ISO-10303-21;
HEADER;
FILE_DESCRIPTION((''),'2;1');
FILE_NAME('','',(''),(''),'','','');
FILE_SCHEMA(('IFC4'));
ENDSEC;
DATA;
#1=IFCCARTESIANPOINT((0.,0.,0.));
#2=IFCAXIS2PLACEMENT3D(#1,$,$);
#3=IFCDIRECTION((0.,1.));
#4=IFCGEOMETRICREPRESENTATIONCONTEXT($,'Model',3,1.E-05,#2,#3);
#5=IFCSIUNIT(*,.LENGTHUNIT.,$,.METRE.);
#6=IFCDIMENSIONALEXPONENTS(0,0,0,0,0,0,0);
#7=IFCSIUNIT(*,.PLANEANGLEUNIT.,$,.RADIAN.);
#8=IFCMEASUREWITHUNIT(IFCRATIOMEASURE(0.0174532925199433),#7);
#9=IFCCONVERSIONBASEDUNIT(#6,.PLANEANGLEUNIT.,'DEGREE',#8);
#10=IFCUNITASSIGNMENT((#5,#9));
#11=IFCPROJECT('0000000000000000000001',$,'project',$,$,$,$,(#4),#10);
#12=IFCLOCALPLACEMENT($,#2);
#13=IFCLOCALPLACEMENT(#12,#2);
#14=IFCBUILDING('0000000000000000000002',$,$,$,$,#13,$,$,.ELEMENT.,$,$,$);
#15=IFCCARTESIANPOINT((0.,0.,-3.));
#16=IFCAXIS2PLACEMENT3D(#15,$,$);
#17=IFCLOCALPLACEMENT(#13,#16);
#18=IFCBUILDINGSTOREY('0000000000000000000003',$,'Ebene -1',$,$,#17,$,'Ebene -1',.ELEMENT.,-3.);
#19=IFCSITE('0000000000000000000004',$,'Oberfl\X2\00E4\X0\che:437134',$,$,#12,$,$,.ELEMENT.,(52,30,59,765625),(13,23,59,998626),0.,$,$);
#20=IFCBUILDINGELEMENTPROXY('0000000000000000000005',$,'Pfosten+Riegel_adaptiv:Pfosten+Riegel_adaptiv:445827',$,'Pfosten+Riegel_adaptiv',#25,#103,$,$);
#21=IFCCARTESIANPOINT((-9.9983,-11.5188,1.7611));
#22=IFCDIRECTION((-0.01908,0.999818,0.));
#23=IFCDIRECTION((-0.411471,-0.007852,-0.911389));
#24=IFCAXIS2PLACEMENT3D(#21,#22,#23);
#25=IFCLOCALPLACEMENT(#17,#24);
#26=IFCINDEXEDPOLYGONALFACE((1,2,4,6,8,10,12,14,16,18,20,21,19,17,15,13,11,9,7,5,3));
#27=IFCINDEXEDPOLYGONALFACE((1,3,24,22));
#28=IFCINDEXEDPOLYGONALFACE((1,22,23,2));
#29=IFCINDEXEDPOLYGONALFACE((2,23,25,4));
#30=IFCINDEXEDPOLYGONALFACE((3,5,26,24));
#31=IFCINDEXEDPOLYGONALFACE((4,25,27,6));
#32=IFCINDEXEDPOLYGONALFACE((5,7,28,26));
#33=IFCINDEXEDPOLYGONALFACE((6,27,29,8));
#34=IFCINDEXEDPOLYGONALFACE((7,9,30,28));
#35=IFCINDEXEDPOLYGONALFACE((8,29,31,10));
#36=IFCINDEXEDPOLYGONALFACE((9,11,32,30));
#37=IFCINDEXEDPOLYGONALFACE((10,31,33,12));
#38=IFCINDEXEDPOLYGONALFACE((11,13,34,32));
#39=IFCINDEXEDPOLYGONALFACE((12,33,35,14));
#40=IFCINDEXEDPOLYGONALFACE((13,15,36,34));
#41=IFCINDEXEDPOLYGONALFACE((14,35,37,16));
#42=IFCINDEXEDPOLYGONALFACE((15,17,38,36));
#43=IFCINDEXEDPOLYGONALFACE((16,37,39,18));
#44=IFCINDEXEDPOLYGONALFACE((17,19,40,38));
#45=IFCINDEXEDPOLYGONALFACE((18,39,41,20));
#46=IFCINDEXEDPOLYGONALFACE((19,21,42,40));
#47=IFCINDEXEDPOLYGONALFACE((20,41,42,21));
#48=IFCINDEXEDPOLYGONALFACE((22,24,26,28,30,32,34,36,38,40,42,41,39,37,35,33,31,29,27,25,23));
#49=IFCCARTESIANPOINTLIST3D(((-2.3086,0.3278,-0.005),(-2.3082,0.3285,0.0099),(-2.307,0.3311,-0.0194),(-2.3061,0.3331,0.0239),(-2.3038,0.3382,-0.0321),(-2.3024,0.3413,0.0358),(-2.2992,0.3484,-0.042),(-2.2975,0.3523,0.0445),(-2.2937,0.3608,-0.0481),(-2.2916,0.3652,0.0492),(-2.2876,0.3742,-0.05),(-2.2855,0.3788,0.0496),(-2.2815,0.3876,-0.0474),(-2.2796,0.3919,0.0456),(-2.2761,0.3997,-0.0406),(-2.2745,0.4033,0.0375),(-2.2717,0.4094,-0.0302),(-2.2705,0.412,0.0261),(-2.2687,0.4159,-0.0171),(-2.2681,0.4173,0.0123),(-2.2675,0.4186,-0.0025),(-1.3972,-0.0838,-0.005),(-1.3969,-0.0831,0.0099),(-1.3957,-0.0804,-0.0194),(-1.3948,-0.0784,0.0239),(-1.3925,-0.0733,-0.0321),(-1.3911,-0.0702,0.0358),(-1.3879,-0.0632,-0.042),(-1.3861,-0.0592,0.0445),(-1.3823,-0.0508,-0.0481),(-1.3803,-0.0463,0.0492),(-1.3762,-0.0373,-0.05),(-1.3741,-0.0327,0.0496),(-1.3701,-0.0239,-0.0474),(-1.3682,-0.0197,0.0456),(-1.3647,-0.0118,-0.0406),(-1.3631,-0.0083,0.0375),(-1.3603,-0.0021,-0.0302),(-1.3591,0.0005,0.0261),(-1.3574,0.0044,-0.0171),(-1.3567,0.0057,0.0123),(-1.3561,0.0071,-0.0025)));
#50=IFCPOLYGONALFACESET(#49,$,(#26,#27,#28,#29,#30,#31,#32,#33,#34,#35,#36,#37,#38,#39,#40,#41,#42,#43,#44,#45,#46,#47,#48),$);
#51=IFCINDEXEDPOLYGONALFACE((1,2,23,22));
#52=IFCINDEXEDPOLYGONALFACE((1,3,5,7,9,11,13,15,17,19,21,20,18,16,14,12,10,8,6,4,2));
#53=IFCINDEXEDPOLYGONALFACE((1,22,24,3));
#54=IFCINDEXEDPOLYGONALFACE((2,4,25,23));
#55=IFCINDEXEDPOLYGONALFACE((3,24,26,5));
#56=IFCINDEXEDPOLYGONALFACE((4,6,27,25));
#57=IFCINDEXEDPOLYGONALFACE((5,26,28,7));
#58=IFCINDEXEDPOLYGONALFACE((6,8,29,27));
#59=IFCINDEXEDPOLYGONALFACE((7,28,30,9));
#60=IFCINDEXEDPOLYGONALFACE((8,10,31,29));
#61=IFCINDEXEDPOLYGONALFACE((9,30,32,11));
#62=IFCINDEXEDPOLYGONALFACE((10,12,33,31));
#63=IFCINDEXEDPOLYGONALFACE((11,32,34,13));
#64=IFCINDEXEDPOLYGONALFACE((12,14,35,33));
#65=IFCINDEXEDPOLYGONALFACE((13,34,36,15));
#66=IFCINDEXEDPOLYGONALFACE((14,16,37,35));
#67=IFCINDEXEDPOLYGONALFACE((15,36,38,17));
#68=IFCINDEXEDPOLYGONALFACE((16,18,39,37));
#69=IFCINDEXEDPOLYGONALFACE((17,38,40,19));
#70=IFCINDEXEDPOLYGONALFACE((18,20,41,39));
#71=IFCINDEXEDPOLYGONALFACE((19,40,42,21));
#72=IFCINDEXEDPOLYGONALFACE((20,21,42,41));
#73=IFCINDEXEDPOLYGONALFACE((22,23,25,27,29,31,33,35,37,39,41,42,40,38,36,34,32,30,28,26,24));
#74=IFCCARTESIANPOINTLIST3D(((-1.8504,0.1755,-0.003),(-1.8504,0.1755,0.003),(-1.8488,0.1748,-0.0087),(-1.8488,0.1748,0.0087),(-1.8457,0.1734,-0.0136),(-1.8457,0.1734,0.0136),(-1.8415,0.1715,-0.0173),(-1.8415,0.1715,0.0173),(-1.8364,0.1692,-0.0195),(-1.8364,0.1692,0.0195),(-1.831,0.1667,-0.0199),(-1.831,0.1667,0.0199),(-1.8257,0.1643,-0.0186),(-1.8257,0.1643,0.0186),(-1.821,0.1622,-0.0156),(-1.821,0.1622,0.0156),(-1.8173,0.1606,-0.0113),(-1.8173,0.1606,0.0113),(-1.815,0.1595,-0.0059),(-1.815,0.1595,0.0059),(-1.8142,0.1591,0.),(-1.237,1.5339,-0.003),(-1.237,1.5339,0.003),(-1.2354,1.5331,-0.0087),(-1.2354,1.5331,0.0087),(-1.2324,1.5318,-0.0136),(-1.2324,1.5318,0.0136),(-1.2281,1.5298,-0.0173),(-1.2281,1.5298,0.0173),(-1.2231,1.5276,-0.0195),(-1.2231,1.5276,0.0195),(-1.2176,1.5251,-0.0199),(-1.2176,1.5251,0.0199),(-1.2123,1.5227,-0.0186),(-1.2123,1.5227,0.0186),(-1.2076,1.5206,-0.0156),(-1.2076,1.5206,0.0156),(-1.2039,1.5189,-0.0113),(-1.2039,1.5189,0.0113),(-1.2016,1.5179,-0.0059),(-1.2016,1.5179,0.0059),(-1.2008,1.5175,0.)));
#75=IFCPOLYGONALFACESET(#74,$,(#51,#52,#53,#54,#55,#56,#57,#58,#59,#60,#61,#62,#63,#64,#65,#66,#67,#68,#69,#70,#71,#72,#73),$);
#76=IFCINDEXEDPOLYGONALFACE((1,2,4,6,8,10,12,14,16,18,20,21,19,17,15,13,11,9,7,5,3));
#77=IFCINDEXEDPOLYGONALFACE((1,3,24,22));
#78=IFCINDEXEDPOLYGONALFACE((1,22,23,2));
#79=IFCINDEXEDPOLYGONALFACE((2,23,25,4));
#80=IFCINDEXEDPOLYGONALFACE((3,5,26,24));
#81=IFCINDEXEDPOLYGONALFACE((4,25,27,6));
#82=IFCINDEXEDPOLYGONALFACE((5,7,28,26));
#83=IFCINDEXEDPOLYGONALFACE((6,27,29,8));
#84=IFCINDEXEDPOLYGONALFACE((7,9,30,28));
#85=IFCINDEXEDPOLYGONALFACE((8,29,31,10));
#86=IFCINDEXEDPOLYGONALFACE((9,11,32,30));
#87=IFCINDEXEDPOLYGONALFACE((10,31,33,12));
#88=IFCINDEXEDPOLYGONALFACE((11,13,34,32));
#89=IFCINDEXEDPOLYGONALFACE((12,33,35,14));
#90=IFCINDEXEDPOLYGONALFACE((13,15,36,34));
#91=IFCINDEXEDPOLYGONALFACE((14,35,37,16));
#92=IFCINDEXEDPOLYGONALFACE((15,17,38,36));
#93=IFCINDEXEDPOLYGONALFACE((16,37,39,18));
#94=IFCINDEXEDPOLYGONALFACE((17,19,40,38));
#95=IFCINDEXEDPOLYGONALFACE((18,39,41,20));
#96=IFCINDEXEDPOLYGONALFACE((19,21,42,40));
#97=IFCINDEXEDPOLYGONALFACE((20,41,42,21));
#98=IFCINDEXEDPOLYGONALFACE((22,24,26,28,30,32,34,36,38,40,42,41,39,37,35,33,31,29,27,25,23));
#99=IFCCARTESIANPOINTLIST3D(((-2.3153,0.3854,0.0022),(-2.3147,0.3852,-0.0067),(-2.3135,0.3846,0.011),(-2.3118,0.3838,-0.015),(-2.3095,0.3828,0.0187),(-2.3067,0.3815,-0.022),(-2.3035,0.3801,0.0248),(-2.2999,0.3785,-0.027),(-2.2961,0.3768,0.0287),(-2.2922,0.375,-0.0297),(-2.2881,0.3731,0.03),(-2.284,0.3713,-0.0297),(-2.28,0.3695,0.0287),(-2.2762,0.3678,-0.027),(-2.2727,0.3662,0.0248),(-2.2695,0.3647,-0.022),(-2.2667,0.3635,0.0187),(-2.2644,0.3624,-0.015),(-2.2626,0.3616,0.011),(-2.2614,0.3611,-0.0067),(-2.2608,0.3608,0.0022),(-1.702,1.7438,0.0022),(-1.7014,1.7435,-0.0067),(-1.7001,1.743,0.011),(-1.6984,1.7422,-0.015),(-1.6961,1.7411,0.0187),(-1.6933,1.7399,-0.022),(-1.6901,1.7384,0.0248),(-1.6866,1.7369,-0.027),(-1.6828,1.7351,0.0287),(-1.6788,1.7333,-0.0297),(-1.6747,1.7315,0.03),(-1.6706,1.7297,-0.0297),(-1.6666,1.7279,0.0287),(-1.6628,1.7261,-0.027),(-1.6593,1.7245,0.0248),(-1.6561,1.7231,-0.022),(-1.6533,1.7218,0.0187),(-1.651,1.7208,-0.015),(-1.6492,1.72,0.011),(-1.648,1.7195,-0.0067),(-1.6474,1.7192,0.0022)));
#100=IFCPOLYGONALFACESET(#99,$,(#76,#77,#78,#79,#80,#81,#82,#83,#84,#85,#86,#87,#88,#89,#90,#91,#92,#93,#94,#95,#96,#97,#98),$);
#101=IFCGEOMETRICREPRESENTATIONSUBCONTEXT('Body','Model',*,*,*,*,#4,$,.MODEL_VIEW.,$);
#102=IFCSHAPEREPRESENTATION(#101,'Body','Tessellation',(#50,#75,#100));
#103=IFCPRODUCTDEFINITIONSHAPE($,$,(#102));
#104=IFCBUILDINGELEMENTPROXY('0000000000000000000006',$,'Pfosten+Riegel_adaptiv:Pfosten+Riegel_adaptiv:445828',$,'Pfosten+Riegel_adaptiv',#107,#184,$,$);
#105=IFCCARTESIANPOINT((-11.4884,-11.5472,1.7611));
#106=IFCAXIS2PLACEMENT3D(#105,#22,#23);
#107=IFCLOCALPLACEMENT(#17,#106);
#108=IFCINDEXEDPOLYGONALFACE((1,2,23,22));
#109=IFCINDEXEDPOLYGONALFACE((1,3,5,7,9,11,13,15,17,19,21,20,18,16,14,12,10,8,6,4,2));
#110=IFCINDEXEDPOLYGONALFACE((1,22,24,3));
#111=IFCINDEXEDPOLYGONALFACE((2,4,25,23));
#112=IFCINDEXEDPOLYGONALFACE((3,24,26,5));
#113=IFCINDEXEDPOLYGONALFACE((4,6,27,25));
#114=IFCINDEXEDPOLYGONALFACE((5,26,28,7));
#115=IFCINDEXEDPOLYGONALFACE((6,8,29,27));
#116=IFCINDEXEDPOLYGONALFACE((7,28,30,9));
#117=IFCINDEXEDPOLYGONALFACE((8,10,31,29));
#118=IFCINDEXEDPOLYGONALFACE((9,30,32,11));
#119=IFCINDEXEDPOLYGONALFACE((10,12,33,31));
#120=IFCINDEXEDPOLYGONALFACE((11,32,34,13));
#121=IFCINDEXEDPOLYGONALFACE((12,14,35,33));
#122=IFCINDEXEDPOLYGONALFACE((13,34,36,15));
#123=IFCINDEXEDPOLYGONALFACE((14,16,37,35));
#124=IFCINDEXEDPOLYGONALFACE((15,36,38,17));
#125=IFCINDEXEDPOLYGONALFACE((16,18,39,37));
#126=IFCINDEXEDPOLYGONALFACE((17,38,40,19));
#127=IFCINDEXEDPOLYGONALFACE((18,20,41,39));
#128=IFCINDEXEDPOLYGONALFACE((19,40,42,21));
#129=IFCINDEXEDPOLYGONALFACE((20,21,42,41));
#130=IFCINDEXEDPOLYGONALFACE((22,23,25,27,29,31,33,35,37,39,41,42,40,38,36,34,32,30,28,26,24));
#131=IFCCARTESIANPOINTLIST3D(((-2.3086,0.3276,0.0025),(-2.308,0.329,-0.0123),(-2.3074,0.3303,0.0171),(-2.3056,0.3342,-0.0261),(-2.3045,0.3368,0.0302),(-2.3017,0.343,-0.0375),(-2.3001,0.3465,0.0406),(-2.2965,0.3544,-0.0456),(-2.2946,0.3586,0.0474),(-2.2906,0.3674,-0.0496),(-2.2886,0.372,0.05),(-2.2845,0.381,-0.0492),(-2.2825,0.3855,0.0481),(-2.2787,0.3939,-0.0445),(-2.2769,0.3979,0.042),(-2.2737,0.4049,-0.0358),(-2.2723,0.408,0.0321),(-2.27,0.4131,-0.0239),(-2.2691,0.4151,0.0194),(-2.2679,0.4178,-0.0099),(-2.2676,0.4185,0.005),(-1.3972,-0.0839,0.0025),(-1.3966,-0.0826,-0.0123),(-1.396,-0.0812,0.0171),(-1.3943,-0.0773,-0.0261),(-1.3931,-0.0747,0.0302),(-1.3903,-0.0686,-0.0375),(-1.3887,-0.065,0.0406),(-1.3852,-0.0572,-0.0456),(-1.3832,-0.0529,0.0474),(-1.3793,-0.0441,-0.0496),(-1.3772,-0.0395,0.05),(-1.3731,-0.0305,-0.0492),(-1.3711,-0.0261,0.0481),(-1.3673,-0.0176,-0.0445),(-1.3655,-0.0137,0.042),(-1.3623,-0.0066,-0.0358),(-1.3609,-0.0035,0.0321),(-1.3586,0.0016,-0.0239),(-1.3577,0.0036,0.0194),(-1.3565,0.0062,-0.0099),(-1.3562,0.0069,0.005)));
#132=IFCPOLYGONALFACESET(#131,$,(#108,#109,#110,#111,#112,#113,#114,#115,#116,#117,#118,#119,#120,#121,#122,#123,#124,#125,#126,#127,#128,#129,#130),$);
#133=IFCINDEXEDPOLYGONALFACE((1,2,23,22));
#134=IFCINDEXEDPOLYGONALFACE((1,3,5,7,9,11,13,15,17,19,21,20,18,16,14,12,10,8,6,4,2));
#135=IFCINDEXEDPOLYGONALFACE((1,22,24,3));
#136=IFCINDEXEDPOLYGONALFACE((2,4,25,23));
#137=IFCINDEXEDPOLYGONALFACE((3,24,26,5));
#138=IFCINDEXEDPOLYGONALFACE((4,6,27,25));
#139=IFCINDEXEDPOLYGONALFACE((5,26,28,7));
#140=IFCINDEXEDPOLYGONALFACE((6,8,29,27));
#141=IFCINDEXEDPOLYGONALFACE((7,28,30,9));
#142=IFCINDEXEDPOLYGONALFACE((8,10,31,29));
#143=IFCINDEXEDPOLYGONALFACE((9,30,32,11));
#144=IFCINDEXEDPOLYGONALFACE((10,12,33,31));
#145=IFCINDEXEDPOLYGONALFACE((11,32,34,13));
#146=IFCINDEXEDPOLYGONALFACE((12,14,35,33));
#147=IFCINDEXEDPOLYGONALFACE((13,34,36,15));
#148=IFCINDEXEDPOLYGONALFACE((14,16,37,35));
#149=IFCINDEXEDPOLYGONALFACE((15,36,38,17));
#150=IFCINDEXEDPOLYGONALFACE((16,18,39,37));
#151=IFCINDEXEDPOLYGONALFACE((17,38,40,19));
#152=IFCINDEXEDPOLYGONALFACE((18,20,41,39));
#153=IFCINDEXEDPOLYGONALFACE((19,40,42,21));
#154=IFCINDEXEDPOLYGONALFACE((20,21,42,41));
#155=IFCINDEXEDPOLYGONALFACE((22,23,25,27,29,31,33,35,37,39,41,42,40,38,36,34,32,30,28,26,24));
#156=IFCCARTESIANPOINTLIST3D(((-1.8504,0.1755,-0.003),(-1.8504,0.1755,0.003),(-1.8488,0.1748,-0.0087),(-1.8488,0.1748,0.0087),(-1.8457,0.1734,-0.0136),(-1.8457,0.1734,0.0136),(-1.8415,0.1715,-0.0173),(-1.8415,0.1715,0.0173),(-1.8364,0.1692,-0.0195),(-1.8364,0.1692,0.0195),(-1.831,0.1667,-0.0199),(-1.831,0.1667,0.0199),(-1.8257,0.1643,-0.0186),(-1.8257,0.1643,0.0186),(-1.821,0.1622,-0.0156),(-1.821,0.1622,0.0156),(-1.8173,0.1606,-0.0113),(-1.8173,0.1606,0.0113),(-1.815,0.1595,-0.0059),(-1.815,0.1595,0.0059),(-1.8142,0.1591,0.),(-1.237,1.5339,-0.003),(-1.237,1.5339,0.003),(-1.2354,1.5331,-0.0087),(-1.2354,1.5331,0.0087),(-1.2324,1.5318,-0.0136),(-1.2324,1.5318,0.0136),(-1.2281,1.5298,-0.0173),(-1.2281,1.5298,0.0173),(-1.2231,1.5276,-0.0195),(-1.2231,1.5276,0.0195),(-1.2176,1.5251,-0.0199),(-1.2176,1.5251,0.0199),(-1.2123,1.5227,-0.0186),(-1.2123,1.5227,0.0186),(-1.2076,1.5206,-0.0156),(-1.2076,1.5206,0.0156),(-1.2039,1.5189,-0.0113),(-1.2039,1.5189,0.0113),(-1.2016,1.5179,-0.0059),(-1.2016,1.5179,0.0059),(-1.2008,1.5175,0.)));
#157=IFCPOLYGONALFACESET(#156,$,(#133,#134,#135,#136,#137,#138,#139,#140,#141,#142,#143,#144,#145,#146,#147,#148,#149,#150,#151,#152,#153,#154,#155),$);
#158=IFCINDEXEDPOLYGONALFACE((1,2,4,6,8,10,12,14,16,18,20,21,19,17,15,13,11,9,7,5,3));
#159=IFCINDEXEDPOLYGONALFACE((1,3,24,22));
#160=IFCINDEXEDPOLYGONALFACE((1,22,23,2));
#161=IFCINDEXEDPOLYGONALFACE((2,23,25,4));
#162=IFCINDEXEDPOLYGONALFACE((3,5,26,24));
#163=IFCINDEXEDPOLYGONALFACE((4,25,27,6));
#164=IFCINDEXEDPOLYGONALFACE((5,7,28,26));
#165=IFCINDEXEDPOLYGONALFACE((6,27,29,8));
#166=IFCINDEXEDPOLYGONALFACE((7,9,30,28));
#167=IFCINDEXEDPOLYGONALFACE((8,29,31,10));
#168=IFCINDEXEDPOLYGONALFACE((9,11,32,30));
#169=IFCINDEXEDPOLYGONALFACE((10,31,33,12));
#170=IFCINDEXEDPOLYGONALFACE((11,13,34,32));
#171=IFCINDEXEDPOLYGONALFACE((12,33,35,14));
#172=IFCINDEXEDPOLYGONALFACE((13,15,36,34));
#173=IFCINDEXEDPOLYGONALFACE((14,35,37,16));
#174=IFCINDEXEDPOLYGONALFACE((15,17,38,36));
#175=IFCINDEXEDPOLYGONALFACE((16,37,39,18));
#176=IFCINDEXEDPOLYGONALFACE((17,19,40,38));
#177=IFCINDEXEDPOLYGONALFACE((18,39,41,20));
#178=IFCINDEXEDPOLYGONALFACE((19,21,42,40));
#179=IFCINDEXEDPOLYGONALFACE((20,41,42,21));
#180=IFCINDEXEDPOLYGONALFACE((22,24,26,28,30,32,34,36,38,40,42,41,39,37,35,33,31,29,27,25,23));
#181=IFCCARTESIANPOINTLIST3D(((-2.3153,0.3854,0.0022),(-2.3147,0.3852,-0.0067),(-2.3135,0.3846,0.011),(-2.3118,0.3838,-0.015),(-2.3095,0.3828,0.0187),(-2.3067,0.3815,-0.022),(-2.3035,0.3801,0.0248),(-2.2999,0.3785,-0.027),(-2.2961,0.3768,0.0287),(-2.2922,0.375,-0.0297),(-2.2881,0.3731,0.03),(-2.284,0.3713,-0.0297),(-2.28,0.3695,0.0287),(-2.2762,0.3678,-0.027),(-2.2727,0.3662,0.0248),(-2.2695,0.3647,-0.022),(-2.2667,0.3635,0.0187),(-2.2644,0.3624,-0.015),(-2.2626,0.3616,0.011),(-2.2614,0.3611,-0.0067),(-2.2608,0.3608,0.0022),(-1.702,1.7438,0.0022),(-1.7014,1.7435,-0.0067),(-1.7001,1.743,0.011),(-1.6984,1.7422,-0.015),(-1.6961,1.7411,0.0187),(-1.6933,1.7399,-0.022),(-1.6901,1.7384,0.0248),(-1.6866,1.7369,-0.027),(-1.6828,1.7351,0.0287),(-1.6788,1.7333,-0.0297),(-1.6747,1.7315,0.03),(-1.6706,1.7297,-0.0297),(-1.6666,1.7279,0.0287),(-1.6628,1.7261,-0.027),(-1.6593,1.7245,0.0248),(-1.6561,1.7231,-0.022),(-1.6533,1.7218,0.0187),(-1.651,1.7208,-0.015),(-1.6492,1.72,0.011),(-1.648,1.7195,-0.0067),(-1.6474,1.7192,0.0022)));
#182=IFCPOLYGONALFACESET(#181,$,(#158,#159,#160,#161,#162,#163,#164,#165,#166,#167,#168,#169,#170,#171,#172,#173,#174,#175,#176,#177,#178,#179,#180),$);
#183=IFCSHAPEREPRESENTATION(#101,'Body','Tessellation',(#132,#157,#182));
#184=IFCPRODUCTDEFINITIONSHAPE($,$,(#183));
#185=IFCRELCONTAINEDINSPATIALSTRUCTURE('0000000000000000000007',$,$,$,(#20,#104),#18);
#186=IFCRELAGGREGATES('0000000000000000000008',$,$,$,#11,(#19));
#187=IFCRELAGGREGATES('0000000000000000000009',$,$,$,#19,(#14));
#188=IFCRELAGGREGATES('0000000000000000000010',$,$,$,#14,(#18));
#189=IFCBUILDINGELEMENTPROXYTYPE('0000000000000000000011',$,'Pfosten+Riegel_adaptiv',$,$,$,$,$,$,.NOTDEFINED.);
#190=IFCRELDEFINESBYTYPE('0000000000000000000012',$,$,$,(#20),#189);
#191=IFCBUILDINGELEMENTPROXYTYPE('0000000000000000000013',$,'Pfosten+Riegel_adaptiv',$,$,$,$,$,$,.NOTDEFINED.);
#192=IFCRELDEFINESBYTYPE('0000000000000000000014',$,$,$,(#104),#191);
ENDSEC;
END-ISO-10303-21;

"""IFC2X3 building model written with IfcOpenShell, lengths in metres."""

from ifc_helpers import new_model, entity, si_unit, converted_unit, direction, frame, frame_2d, origin, place, context, subcontext, project, spatial, circle, extrude, source, transform, mapped, type_object, type_shapes, element, save


model = new_model("IFC2X3")

# Units and contexts
model_context = context("Model", 3, precision=1e-05, world=origin(), true_north=direction((0.0, 1.0)))
body_context = subcontext(model_context, "Body", "Model", "MODEL_VIEW")
ifc_project = project(units=[si_unit("LENGTHUNIT", "METRE"), converted_unit("PLANEANGLEUNIT", "DEGREE", entity("IfcRatioMeasure", 0.0174532925199433), si_unit("PLANEANGLEUNIT", "RADIAN"), dimensions=[0, 0, 0, 0, 0, 0, 0])], contexts=[model_context])

# Site, building, storey
site_placement = place(None, origin())
site = spatial("IfcSite", under=ifc_project, at=site_placement, Name="Oberfläche:437134", CompositionType="ELEMENT", RefLatitude=(52, 30, 59, 765625), RefLongitude=(13, 23, 59, 998626), RefElevation=0.0)
building_placement = place(site_placement, origin())
building = spatial("IfcBuilding", under=site, at=building_placement, CompositionType="ELEMENT")
storey_placement = place(building_placement, frame((0.0, 0.0, -3.0)))
storey = spatial("IfcBuildingStorey", under=building, at=storey_placement, Name="Ebene -1", LongName="Ebene -1", CompositionType="ELEMENT", Elevation=-3.0)

# Building element proxies
building_element_proxy_type_1 = type_object("IfcBuildingElementProxyType", Name="Pfosten+Riegel_adaptiv", PredefinedType="NOTDEFINED")
shared_shape_1 = source(origin(), body_context, "Body", "SweptSolid", [
    extrude(circle(Radius=0.05, at=frame_2d((0.0, 0.0), x_axis=(1.0, 0.0))), frame((-2.2881, 0.3731, 0.0), z_axis=(0.911389, -0.411546, 0.0), x_axis=(0.16937, 0.375078, 0.911389)), (0.0, 0.0, 1.0), 1.0),
    extrude(circle(Radius=0.02, at=frame_2d((0.0, 0.0), x_axis=(1.0, 0.0))), frame((-1.8324, 0.1674, 0.0), z_axis=(0.411546, 0.911389, 0.0), x_axis=(0.911389, -0.411546, 0.0)), (0.0, 0.0, 1.0), 1.4904),
    extrude(circle(Radius=0.03, at=frame_2d((0.0, 0.0), x_axis=(1.0, 0.0))), frame((-2.2881, 0.3731, 0.0), z_axis=(0.411546, 0.911389, 0.0), x_axis=(0.0, 0.0, 1.0)), (0.0, 0.0, 1.0), 1.4904),
])
type_shapes(building_element_proxy_type_1, [shared_shape_1])
for number, where, z_axis, x_axis, name in (
    (1, (-9.9983, -11.5188, 1.7611), (-0.01908, 0.999818, 0.0), (-0.411471, -0.007852, -0.911389), "Pfosten+Riegel_adaptiv:Pfosten+Riegel_adaptiv:445827"),
):
    element("IfcBuildingElementProxy", number, at=place(storey_placement, frame(where, z_axis=z_axis, x_axis=x_axis)), inside=storey, type_object=building_element_proxy_type_1, Name=name, ObjectType="Pfosten+Riegel_adaptiv", context=body_context, shape_type="MappedRepresentation", body=[
        mapped(shared_shape_1, transform((0.0, 0.0, 0.0), scale=1.0)),
    ])
building_element_proxy_type_2 = type_object("IfcBuildingElementProxyType", Name="Pfosten+Riegel_adaptiv", PredefinedType="NOTDEFINED")
shared_shape_2 = source(origin(), body_context, "Body", "SweptSolid", [
    extrude(circle(Radius=0.05, at=frame_2d((0.0, 0.0), x_axis=(1.0, 0.0))), frame((-1.3767, -0.0384, 0.0), z_axis=(-0.911389, 0.411546, 0.0), x_axis=(-0.16937, -0.375078, -0.911389)), (0.0, 0.0, 1.0), 1.0),
    extrude(circle(Radius=0.02, at=frame_2d((0.0, 0.0), x_axis=(1.0, 0.0))), frame((-1.8324, 0.1674, 0.0), z_axis=(0.411546, 0.911389, 0.0), x_axis=(0.911389, -0.411546, 0.0)), (0.0, 0.0, 1.0), 1.4904),
    extrude(circle(Radius=0.03, at=frame_2d((0.0, 0.0), x_axis=(1.0, 0.0))), frame((-2.2881, 0.3731, 0.0), z_axis=(0.411546, 0.911389, 0.0), x_axis=(0.0, 0.0, 1.0)), (0.0, 0.0, 1.0), 1.4904),
])
type_shapes(building_element_proxy_type_2, [shared_shape_2])
proxy_1_placement = place(storey_placement, frame((-11.4884, -11.5472, 1.7611), z_axis=(-0.01908, 0.999818, 0.0), x_axis=(-0.411471, -0.007852, -0.911389)))
element("IfcBuildingElementProxy", 2, at=proxy_1_placement, inside=storey, type_object=building_element_proxy_type_2, Name="Pfosten+Riegel_adaptiv:Pfosten+Riegel_adaptiv:445828", ObjectType="Pfosten+Riegel_adaptiv", context=body_context, shape_type="MappedRepresentation", body=[
    mapped(shared_shape_2, transform((0.0, 0.0, 0.0), scale=1.0)),
])

save(model, "model.ifc")
